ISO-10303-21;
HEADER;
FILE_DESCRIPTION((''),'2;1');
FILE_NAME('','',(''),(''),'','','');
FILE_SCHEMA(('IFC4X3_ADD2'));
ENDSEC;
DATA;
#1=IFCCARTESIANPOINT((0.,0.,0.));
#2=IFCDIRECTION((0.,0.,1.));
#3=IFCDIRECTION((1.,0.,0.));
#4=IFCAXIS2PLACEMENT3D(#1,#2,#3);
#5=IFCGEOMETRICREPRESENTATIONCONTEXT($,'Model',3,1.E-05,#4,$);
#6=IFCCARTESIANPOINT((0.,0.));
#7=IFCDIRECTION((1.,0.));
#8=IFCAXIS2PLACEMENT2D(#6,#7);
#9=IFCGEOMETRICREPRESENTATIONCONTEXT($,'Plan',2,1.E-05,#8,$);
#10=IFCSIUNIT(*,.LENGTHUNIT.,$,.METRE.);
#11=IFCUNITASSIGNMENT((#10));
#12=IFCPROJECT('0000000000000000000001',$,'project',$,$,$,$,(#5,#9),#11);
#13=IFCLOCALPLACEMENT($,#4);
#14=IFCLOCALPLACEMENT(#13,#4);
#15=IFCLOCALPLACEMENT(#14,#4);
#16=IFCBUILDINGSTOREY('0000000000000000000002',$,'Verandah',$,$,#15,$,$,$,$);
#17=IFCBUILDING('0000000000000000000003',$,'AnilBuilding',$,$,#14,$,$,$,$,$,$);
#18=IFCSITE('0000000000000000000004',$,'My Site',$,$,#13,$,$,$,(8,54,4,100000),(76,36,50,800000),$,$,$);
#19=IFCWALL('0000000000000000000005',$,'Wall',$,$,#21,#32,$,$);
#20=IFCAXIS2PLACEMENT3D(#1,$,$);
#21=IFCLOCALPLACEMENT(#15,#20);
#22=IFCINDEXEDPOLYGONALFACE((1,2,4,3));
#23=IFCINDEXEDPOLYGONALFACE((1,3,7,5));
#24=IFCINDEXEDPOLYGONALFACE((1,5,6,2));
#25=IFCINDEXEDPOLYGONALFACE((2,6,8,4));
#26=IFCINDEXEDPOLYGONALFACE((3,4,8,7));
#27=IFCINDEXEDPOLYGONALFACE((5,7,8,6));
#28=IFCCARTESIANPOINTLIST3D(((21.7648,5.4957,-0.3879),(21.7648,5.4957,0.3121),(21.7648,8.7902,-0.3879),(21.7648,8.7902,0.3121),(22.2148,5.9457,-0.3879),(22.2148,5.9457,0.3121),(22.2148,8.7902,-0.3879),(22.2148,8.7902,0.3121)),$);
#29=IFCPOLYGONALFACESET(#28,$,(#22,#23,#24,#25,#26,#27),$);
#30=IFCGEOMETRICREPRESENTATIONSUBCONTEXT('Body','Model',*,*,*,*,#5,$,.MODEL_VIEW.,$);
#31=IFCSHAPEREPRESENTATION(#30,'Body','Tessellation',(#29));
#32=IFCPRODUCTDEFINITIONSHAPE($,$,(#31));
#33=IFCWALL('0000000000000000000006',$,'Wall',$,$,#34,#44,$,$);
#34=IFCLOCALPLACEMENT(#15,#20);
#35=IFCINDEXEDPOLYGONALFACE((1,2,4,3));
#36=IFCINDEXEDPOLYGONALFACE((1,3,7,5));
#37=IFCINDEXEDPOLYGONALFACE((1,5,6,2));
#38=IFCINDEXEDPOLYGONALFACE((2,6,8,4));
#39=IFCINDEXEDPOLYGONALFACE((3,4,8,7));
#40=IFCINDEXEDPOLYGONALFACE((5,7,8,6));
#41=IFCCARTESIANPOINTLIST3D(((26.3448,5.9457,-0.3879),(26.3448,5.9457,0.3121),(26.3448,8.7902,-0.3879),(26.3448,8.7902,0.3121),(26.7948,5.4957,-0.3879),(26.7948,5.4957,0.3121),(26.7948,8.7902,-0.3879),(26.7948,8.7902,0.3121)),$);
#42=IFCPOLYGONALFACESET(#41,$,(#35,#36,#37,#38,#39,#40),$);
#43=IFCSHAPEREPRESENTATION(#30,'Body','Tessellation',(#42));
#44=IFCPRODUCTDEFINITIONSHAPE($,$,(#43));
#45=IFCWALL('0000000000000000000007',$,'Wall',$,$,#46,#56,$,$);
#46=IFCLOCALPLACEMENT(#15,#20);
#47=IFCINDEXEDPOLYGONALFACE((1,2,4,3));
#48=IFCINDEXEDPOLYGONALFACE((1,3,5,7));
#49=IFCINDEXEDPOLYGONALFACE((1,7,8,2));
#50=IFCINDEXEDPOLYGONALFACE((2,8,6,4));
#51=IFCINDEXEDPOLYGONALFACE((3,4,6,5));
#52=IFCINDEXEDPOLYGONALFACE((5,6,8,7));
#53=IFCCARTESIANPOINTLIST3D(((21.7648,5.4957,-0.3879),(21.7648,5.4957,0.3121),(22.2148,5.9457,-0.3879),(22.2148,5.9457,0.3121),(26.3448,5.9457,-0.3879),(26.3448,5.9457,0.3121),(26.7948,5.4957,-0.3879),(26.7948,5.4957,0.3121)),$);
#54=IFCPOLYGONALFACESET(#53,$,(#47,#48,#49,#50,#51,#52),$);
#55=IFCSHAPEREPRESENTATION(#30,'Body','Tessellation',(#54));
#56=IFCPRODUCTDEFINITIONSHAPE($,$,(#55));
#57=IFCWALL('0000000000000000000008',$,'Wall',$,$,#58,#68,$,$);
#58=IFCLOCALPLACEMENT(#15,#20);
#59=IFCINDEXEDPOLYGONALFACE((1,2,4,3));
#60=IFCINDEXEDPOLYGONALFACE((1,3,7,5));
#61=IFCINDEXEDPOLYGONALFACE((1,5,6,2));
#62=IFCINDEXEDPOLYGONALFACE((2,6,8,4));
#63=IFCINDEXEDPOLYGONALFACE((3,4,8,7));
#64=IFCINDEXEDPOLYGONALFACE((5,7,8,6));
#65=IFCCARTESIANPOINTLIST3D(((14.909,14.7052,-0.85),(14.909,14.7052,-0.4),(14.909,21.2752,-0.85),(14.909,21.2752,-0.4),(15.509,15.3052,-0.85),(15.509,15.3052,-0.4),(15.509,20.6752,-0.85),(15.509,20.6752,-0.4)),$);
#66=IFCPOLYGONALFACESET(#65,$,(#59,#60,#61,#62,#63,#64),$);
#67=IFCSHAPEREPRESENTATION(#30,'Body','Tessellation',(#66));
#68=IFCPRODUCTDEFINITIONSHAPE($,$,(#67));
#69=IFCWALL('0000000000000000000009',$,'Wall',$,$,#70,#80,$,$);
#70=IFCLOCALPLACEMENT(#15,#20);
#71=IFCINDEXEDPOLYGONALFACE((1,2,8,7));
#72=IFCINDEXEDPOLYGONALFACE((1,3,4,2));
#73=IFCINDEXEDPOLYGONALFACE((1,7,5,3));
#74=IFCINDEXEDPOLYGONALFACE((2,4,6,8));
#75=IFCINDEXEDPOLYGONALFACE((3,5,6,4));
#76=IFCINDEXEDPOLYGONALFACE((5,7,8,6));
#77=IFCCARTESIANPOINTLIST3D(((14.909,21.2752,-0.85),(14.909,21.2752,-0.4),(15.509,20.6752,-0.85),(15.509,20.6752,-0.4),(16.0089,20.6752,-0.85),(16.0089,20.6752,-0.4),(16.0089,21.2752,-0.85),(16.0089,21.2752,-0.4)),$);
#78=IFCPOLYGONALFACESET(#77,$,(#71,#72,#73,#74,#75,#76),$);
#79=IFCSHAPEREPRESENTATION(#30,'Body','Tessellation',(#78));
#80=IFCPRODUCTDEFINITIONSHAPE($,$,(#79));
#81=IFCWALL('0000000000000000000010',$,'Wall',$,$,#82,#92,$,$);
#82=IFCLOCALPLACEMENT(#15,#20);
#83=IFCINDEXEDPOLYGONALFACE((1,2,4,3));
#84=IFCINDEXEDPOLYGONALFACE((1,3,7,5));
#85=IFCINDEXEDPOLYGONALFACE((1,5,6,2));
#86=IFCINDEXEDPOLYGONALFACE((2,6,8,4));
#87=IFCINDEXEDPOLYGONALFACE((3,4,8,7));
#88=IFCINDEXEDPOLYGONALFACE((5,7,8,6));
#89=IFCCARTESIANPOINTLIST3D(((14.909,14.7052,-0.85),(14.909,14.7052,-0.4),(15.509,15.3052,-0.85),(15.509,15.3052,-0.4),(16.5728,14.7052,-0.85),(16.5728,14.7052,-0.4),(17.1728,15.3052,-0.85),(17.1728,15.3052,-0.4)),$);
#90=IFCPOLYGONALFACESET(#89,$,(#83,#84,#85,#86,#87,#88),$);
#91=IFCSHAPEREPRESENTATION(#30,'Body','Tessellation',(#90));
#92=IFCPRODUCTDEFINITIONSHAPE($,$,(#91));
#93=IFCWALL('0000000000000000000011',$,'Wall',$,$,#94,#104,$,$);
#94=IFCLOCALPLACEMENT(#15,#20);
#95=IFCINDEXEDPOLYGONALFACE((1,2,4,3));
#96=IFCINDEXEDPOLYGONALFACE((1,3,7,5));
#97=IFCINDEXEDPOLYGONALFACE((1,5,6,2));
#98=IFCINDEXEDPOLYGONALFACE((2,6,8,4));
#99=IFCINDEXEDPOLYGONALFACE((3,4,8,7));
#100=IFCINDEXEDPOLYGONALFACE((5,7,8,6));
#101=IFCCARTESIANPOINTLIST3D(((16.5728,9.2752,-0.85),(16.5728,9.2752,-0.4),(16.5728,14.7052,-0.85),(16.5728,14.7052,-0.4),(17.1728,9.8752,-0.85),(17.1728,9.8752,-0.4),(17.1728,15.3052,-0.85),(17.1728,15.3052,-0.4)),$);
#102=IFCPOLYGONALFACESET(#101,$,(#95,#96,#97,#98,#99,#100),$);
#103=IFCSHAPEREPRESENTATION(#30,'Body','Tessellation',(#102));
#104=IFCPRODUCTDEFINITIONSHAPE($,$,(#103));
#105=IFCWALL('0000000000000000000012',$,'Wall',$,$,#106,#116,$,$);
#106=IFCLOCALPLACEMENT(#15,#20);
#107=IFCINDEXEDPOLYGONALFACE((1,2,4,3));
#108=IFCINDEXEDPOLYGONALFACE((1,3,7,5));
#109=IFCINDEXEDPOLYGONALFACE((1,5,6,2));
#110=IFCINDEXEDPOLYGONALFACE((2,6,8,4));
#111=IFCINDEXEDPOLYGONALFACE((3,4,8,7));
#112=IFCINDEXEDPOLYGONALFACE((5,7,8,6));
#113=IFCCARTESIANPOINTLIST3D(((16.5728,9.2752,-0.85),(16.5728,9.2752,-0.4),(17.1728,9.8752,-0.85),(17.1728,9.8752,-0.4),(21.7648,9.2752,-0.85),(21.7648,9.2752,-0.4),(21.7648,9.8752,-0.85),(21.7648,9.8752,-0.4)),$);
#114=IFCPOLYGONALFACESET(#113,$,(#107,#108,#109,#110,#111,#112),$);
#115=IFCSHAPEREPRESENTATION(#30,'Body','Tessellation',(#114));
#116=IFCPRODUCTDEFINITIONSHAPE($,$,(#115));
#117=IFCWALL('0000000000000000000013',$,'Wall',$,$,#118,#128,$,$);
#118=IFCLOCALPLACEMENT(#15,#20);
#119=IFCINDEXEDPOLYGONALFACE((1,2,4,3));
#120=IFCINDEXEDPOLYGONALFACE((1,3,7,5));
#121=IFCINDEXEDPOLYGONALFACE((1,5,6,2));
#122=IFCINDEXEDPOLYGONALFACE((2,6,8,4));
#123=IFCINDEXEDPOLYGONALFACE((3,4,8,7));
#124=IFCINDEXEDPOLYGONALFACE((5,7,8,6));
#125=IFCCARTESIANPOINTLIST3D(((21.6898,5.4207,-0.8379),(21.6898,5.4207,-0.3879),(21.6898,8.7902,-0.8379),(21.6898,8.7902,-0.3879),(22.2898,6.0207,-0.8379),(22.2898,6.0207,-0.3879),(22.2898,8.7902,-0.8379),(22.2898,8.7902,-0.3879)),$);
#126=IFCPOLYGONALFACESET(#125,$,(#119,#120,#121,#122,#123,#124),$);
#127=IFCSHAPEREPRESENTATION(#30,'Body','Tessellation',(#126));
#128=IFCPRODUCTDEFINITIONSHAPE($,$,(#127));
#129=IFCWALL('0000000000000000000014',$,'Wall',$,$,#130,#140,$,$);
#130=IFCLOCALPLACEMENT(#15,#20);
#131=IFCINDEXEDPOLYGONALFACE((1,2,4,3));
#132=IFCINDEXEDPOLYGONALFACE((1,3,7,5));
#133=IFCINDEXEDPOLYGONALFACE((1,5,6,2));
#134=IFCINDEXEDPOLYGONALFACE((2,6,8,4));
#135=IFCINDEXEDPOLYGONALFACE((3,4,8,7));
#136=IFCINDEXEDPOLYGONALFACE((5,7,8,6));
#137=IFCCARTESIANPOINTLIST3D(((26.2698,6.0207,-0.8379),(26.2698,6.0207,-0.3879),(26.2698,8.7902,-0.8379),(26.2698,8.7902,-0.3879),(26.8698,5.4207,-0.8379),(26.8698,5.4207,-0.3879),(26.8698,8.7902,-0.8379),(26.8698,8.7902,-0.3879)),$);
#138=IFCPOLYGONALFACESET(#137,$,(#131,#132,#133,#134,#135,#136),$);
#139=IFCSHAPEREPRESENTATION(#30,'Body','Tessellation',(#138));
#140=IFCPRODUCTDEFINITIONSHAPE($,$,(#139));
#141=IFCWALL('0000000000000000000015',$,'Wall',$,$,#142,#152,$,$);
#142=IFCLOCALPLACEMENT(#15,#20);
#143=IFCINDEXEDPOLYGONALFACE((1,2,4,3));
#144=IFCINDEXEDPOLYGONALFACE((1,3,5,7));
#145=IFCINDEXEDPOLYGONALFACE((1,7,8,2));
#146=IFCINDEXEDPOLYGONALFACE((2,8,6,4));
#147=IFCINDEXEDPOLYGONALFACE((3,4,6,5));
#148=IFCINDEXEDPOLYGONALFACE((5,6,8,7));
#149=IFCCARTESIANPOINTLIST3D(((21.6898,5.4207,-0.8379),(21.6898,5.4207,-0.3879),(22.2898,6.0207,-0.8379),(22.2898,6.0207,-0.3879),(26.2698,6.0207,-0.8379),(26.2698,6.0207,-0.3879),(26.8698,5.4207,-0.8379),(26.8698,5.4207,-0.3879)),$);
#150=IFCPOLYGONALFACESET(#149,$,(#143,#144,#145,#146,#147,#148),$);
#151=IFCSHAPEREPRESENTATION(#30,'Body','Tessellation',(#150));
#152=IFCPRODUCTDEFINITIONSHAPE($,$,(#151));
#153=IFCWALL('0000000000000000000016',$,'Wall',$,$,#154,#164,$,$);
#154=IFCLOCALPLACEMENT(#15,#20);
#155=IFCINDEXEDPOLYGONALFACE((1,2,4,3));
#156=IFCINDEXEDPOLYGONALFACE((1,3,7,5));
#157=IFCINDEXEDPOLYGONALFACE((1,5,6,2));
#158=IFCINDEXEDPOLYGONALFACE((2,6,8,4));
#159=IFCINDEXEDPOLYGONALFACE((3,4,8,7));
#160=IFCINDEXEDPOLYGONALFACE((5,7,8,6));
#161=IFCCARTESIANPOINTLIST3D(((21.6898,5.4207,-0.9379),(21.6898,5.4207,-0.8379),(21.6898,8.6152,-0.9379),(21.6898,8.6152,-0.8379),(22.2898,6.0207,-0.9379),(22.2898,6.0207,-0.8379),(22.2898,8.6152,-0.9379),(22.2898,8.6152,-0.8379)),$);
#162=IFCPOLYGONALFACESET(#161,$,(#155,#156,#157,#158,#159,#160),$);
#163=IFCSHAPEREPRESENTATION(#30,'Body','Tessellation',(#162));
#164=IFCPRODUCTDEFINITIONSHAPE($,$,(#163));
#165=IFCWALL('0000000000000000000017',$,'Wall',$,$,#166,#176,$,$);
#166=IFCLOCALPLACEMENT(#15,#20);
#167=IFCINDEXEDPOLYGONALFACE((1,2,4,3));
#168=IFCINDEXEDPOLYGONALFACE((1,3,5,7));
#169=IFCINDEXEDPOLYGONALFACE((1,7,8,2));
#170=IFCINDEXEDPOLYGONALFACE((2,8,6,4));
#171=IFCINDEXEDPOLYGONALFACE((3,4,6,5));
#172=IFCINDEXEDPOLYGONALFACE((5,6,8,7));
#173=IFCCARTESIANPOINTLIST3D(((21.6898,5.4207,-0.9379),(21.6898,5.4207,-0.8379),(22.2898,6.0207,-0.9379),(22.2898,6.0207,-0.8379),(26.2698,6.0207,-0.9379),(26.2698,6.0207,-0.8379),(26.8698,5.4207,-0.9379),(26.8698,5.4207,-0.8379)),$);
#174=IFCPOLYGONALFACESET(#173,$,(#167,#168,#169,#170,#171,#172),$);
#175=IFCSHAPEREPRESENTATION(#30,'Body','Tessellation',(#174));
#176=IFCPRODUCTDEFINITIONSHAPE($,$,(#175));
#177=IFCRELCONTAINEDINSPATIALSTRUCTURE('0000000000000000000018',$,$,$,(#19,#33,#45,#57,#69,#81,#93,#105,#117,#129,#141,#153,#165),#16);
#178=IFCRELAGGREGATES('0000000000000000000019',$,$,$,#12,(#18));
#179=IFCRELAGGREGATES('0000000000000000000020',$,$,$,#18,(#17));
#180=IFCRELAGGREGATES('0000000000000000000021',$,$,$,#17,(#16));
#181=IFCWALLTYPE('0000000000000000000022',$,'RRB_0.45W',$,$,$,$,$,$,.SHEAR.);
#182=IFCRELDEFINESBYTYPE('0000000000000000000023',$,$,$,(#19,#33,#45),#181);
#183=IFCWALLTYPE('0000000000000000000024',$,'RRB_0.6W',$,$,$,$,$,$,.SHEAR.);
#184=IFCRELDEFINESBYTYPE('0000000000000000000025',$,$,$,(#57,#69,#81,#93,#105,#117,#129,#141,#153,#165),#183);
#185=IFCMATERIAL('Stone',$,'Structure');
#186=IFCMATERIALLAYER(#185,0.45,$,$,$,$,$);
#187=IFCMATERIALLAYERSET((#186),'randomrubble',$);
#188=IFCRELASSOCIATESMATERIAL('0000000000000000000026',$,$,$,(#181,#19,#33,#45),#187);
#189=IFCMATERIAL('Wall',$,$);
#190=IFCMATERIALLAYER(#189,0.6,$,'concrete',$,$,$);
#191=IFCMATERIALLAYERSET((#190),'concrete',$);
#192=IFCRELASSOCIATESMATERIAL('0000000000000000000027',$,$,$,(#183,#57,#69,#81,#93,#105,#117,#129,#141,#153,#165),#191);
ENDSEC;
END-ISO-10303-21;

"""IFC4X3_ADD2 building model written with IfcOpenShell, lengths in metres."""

from ifc_helpers import new_model, si_unit, frame, origin_with_axes, origin_2d_with_axis, place, context, subcontext, project, spatial, line, indexed_curve, outline, extrude, material, layer, layer_set, layer_usage, type_object, element, save


model = new_model("IFC4X3_ADD2")

# Units and contexts
model_context = context("Model", 3, precision=1e-05, world=origin_with_axes())
plan_context = context("Plan", 2, precision=1e-05, world=origin_2d_with_axis())
body_context = subcontext(model_context, "Body", "Model", "MODEL_VIEW")
ifc_project = project(units=[si_unit("LENGTHUNIT", "METRE")], contexts=[model_context, plan_context])

# Site, building, storey
site_placement = place(None, origin_with_axes())
site = spatial("IfcSite", under=ifc_project, at=site_placement, Name="My Site", RefLatitude=(8, 54, 4, 100000), RefLongitude=(76, 36, 50, 800000))
building_placement = place(site_placement, origin_with_axes())
building = spatial("IfcBuilding", under=site, at=building_placement, Name="AnilBuilding")
storey_placement = place(building_placement, origin_with_axes())
storey = spatial("IfcBuildingStorey", under=building, at=storey_placement, Name="Verandah")

# Shared definitions
ifc_material_1 = material(Name="Stone", Category="Structure")

# Walls
ifc_layer_1 = layer(ifc_material_1, 0.45)
ifc_layer_set_1 = layer_set([ifc_layer_1], Name="randomrubble")
wall_type_1 = type_object("IfcWallType", Name="RRB_0.45W", PredefinedType="SHEAR", material=ifc_layer_set_1)
ifc_layer_usage_1 = layer_usage(ifc_layer_set_1, "AXIS2", "POSITIVE", 0.0)
wall_1_placement = place(storey_placement, frame((22.2148, 5.4957, -0.3879), z_axis=(0.0, 0.0, 1.0), x_axis=(0.000001, 1.0, 0.0)))
element("IfcWall", 1, at=wall_1_placement, inside=storey, type_object=wall_type_1, material=ifc_layer_usage_1, Name="Wall", context=body_context, shape_type="SweptSolid", body=[
    extrude(outline(indexed_curve([(0.45, 0.0), (0.0, 0.45), (3.2945, 0.45), (3.2945, 0.0)], segments=[line(1, 2, 3, 4, 1)])), origin_with_axes(), (0.0, 0.0, 1.0), 0.7),
])
ifc_layer_usage_2 = layer_usage(ifc_layer_set_1, "AXIS2", "POSITIVE", 0.0)
wall_2_placement = place(storey_placement, frame((26.7948, 5.4957, -0.3879), z_axis=(0.0, 0.0, 1.0), x_axis=(0.000001, 1.0, 0.0)))
element("IfcWall", 2, at=wall_2_placement, inside=storey, type_object=wall_type_1, material=ifc_layer_usage_2, Name="Wall", context=body_context, shape_type="SweptSolid", body=[
    extrude(outline(indexed_curve([(0.0, 0.0), (0.45, 0.45), (3.2945, 0.45), (3.2945, 0.0)], segments=[line(1, 2, 3, 4, 1)])), origin_with_axes(), (0.0, 0.0, 1.0), 0.7),
])
ifc_layer_usage_3 = layer_usage(ifc_layer_set_1, "AXIS2", "POSITIVE", 0.0)
wall_3_placement = place(storey_placement, frame((22.2148, 5.4957, -0.3879), z_axis=(0.0, 0.0, 1.0), x_axis=(1.0, 0.0, 0.0)))
element("IfcWall", 3, at=wall_3_placement, inside=storey, type_object=wall_type_1, material=ifc_layer_usage_3, Name="Wall", context=body_context, shape_type="SweptSolid", body=[
    extrude(outline(indexed_curve([(-0.45, 0.0), (0.0, 0.45), (4.13, 0.45), (4.58, 0.0)], segments=[line(1, 2, 3, 4, 1)])), origin_with_axes(), (0.0, 0.0, 1.0), 0.7),
])
ifc_material_2 = material(Name="Wall")
ifc_layer_2 = layer(ifc_material_2, 0.6, Name="concrete")
ifc_layer_set_2 = layer_set([ifc_layer_2], Name="concrete")
ifc_layer_usage_4 = layer_usage(ifc_layer_set_2, "AXIS2", "POSITIVE", 0.0)
wall_type_2 = type_object("IfcWallType", Name="RRB_0.6W", PredefinedType="SHEAR", material=ifc_layer_set_2)
wall_4_placement = place(storey_placement, frame((15.509, 14.7052, -0.85), z_axis=(0.0, 0.0, 1.0), x_axis=(0.000001, 1.0, 0.0)))
element("IfcWall", 4, at=wall_4_placement, inside=storey, type_object=wall_type_2, material=ifc_layer_usage_4, Name="Wall", context=body_context, shape_type="SweptSolid", body=[
    extrude(outline(indexed_curve([(0.6, 0.0), (0.0, 0.6), (6.57, 0.6), (5.97, 0.0)], segments=[line(1, 2, 3, 4, 1)])), origin_with_axes(), (0.0, 0.0, 1.0), 0.45),
])
ifc_layer_usage_5 = layer_usage(ifc_layer_set_2, "AXIS2", "POSITIVE", 0.0)
wall_5_placement = place(storey_placement, frame((15.509, 20.6752, -0.85), z_axis=(0.0, 0.0, 1.0), x_axis=(1.0, 0.0, 0.0)))
element("IfcWall", 5, at=wall_5_placement, inside=storey, type_object=wall_type_2, material=ifc_layer_usage_5, Name="Wall", context=body_context, shape_type="SweptSolid", body=[
    extrude(outline(indexed_curve([(0.0, 0.0), (-0.6, 0.6), (0.4999, 0.6), (0.4999, 0.0)], segments=[line(1, 2, 3, 4, 1)])), origin_with_axes(), (0.0, 0.0, 1.0), 0.45),
])
ifc_layer_usage_6 = layer_usage(ifc_layer_set_2, "AXIS2", "POSITIVE", 0.0)
wall_6_placement = place(storey_placement, frame((15.509, 14.7052, -0.85), z_axis=(0.0, 0.0, 1.0), x_axis=(1.0, 0.0, 0.0)))
element("IfcWall", 6, at=wall_6_placement, inside=storey, type_object=wall_type_2, material=ifc_layer_usage_6, Name="Wall", context=body_context, shape_type="SweptSolid", body=[
    extrude(outline(indexed_curve([(-0.6, 0.0), (0.0, 0.6), (1.6638, 0.6), (1.0638, 0.0)], segments=[line(1, 2, 3, 4, 1)])), origin_with_axes(), (0.0, 0.0, 1.0), 0.45),
])
ifc_layer_usage_7 = layer_usage(ifc_layer_set_2, "AXIS2", "POSITIVE", 0.0)
wall_7_placement = place(storey_placement, frame((17.1728, 9.2752, -0.85), z_axis=(0.0, 0.0, 1.0), x_axis=(0.000001, 1.0, 0.0)))
element("IfcWall", 7, at=wall_7_placement, inside=storey, type_object=wall_type_2, material=ifc_layer_usage_7, Name="Wall", context=body_context, shape_type="SweptSolid", body=[
    extrude(outline(indexed_curve([(0.6, 0.0), (0.0, 0.6), (5.43, 0.6), (6.03, 0.0)], segments=[line(1, 2, 3, 4, 1)])), origin_with_axes(), (0.0, 0.0, 1.0), 0.45),
])
ifc_layer_usage_8 = layer_usage(ifc_layer_set_2, "AXIS2", "POSITIVE", 0.0)
wall_8_placement = place(storey_placement, frame((17.1728, 9.2752, -0.85), z_axis=(0.0, 0.0, 1.0), x_axis=(1.0, 0.0, 0.0)))
element("IfcWall", 8, at=wall_8_placement, inside=storey, type_object=wall_type_2, material=ifc_layer_usage_8, Name="Wall", context=body_context, shape_type="SweptSolid", body=[
    extrude(outline(indexed_curve([(-0.6, 0.0), (0.0, 0.6), (4.592, 0.6), (4.592, 0.0)], segments=[line(1, 2, 3, 4, 1)])), origin_with_axes(), (0.0, 0.0, 1.0), 0.45),
])
ifc_layer_usage_9 = layer_usage(ifc_layer_set_2, "AXIS2", "POSITIVE", 0.0)
wall_9_placement = place(storey_placement, frame((22.2898, 5.4207, -0.8379), z_axis=(0.0, 0.0, 1.0), x_axis=(0.000001, 1.0, 0.0)))
element("IfcWall", 9, at=wall_9_placement, inside=storey, type_object=wall_type_2, material=ifc_layer_usage_9, Name="Wall", context=body_context, shape_type="SweptSolid", body=[
    extrude(outline(indexed_curve([(0.6, 0.0), (0.0, 0.6), (3.3695, 0.6), (3.3695, 0.0)], segments=[line(1, 2, 3, 4, 1)])), origin_with_axes(), (0.0, 0.0, 1.0), 0.45),
])
ifc_layer_usage_10 = layer_usage(ifc_layer_set_2, "AXIS2", "POSITIVE", 0.0)
wall_10_placement = place(storey_placement, frame((26.8698, 5.4207, -0.8379), z_axis=(0.0, 0.0, 1.0), x_axis=(0.000001, 1.0, 0.0)))
element("IfcWall", 10, at=wall_10_placement, inside=storey, type_object=wall_type_2, material=ifc_layer_usage_10, Name="Wall", context=body_context, shape_type="SweptSolid", body=[
    extrude(outline(indexed_curve([(0.0, 0.0), (0.6, 0.6), (3.3695, 0.6), (3.3695, 0.0)], segments=[line(1, 2, 3, 4, 1)])), origin_with_axes(), (0.0, 0.0, 1.0), 0.45),
])
ifc_layer_usage_11 = layer_usage(ifc_layer_set_2, "AXIS2", "POSITIVE", 0.0)
wall_11_placement = place(storey_placement, frame((22.2898, 5.4207, -0.8379), z_axis=(0.0, 0.0, 1.0), x_axis=(1.0, 0.0, 0.0)))
element("IfcWall", 11, at=wall_11_placement, inside=storey, type_object=wall_type_2, material=ifc_layer_usage_11, Name="Wall", context=body_context, shape_type="SweptSolid", body=[
    extrude(outline(indexed_curve([(-0.6, 0.0), (0.0, 0.6), (3.98, 0.6), (4.58, 0.0)], segments=[line(1, 2, 3, 4, 1)])), origin_with_axes(), (0.0, 0.0, 1.0), 0.45),
])
ifc_layer_usage_12 = layer_usage(ifc_layer_set_2, "AXIS2", "POSITIVE", 0.0)
wall_12_placement = place(storey_placement, frame((22.2898, 6.0207, -0.9379), z_axis=(0.0, 0.0, 1.0), x_axis=(0.000001, 1.0, 0.0)))
element("IfcWall", 12, at=wall_12_placement, inside=storey, type_object=wall_type_2, material=ifc_layer_usage_12, Name="Wall", context=body_context, shape_type="SweptSolid", body=[
    extrude(outline(indexed_curve([(0.0, 0.0), (-0.6, 0.6), (2.5944, 0.6), (2.5944, 0.0)], segments=[line(1, 2, 3, 4, 1)])), origin_with_axes(), (0.0, 0.0, 1.0), 0.1),
])
ifc_layer_usage_13 = layer_usage(ifc_layer_set_2, "AXIS2", "POSITIVE", 0.0)
wall_13_placement = place(storey_placement, frame((26.8698, 6.0207, -0.9379), z_axis=(0.0, 0.0, 1.0), x_axis=(-1.0, 0.000001, 0.0)))
element("IfcWall", 13, at=wall_13_placement, inside=storey, type_object=wall_type_2, material=ifc_layer_usage_13, Name="Wall", context=body_context, shape_type="SweptSolid", body=[
    extrude(outline(indexed_curve([(0.6, 0.0), (0.0, 0.6), (5.18, 0.6), (4.58, 0.0)], segments=[line(1, 2, 3, 4, 1)])), origin_with_axes(), (0.0, 0.0, 1.0), 0.1),
])

save(model, "model.ifc")
